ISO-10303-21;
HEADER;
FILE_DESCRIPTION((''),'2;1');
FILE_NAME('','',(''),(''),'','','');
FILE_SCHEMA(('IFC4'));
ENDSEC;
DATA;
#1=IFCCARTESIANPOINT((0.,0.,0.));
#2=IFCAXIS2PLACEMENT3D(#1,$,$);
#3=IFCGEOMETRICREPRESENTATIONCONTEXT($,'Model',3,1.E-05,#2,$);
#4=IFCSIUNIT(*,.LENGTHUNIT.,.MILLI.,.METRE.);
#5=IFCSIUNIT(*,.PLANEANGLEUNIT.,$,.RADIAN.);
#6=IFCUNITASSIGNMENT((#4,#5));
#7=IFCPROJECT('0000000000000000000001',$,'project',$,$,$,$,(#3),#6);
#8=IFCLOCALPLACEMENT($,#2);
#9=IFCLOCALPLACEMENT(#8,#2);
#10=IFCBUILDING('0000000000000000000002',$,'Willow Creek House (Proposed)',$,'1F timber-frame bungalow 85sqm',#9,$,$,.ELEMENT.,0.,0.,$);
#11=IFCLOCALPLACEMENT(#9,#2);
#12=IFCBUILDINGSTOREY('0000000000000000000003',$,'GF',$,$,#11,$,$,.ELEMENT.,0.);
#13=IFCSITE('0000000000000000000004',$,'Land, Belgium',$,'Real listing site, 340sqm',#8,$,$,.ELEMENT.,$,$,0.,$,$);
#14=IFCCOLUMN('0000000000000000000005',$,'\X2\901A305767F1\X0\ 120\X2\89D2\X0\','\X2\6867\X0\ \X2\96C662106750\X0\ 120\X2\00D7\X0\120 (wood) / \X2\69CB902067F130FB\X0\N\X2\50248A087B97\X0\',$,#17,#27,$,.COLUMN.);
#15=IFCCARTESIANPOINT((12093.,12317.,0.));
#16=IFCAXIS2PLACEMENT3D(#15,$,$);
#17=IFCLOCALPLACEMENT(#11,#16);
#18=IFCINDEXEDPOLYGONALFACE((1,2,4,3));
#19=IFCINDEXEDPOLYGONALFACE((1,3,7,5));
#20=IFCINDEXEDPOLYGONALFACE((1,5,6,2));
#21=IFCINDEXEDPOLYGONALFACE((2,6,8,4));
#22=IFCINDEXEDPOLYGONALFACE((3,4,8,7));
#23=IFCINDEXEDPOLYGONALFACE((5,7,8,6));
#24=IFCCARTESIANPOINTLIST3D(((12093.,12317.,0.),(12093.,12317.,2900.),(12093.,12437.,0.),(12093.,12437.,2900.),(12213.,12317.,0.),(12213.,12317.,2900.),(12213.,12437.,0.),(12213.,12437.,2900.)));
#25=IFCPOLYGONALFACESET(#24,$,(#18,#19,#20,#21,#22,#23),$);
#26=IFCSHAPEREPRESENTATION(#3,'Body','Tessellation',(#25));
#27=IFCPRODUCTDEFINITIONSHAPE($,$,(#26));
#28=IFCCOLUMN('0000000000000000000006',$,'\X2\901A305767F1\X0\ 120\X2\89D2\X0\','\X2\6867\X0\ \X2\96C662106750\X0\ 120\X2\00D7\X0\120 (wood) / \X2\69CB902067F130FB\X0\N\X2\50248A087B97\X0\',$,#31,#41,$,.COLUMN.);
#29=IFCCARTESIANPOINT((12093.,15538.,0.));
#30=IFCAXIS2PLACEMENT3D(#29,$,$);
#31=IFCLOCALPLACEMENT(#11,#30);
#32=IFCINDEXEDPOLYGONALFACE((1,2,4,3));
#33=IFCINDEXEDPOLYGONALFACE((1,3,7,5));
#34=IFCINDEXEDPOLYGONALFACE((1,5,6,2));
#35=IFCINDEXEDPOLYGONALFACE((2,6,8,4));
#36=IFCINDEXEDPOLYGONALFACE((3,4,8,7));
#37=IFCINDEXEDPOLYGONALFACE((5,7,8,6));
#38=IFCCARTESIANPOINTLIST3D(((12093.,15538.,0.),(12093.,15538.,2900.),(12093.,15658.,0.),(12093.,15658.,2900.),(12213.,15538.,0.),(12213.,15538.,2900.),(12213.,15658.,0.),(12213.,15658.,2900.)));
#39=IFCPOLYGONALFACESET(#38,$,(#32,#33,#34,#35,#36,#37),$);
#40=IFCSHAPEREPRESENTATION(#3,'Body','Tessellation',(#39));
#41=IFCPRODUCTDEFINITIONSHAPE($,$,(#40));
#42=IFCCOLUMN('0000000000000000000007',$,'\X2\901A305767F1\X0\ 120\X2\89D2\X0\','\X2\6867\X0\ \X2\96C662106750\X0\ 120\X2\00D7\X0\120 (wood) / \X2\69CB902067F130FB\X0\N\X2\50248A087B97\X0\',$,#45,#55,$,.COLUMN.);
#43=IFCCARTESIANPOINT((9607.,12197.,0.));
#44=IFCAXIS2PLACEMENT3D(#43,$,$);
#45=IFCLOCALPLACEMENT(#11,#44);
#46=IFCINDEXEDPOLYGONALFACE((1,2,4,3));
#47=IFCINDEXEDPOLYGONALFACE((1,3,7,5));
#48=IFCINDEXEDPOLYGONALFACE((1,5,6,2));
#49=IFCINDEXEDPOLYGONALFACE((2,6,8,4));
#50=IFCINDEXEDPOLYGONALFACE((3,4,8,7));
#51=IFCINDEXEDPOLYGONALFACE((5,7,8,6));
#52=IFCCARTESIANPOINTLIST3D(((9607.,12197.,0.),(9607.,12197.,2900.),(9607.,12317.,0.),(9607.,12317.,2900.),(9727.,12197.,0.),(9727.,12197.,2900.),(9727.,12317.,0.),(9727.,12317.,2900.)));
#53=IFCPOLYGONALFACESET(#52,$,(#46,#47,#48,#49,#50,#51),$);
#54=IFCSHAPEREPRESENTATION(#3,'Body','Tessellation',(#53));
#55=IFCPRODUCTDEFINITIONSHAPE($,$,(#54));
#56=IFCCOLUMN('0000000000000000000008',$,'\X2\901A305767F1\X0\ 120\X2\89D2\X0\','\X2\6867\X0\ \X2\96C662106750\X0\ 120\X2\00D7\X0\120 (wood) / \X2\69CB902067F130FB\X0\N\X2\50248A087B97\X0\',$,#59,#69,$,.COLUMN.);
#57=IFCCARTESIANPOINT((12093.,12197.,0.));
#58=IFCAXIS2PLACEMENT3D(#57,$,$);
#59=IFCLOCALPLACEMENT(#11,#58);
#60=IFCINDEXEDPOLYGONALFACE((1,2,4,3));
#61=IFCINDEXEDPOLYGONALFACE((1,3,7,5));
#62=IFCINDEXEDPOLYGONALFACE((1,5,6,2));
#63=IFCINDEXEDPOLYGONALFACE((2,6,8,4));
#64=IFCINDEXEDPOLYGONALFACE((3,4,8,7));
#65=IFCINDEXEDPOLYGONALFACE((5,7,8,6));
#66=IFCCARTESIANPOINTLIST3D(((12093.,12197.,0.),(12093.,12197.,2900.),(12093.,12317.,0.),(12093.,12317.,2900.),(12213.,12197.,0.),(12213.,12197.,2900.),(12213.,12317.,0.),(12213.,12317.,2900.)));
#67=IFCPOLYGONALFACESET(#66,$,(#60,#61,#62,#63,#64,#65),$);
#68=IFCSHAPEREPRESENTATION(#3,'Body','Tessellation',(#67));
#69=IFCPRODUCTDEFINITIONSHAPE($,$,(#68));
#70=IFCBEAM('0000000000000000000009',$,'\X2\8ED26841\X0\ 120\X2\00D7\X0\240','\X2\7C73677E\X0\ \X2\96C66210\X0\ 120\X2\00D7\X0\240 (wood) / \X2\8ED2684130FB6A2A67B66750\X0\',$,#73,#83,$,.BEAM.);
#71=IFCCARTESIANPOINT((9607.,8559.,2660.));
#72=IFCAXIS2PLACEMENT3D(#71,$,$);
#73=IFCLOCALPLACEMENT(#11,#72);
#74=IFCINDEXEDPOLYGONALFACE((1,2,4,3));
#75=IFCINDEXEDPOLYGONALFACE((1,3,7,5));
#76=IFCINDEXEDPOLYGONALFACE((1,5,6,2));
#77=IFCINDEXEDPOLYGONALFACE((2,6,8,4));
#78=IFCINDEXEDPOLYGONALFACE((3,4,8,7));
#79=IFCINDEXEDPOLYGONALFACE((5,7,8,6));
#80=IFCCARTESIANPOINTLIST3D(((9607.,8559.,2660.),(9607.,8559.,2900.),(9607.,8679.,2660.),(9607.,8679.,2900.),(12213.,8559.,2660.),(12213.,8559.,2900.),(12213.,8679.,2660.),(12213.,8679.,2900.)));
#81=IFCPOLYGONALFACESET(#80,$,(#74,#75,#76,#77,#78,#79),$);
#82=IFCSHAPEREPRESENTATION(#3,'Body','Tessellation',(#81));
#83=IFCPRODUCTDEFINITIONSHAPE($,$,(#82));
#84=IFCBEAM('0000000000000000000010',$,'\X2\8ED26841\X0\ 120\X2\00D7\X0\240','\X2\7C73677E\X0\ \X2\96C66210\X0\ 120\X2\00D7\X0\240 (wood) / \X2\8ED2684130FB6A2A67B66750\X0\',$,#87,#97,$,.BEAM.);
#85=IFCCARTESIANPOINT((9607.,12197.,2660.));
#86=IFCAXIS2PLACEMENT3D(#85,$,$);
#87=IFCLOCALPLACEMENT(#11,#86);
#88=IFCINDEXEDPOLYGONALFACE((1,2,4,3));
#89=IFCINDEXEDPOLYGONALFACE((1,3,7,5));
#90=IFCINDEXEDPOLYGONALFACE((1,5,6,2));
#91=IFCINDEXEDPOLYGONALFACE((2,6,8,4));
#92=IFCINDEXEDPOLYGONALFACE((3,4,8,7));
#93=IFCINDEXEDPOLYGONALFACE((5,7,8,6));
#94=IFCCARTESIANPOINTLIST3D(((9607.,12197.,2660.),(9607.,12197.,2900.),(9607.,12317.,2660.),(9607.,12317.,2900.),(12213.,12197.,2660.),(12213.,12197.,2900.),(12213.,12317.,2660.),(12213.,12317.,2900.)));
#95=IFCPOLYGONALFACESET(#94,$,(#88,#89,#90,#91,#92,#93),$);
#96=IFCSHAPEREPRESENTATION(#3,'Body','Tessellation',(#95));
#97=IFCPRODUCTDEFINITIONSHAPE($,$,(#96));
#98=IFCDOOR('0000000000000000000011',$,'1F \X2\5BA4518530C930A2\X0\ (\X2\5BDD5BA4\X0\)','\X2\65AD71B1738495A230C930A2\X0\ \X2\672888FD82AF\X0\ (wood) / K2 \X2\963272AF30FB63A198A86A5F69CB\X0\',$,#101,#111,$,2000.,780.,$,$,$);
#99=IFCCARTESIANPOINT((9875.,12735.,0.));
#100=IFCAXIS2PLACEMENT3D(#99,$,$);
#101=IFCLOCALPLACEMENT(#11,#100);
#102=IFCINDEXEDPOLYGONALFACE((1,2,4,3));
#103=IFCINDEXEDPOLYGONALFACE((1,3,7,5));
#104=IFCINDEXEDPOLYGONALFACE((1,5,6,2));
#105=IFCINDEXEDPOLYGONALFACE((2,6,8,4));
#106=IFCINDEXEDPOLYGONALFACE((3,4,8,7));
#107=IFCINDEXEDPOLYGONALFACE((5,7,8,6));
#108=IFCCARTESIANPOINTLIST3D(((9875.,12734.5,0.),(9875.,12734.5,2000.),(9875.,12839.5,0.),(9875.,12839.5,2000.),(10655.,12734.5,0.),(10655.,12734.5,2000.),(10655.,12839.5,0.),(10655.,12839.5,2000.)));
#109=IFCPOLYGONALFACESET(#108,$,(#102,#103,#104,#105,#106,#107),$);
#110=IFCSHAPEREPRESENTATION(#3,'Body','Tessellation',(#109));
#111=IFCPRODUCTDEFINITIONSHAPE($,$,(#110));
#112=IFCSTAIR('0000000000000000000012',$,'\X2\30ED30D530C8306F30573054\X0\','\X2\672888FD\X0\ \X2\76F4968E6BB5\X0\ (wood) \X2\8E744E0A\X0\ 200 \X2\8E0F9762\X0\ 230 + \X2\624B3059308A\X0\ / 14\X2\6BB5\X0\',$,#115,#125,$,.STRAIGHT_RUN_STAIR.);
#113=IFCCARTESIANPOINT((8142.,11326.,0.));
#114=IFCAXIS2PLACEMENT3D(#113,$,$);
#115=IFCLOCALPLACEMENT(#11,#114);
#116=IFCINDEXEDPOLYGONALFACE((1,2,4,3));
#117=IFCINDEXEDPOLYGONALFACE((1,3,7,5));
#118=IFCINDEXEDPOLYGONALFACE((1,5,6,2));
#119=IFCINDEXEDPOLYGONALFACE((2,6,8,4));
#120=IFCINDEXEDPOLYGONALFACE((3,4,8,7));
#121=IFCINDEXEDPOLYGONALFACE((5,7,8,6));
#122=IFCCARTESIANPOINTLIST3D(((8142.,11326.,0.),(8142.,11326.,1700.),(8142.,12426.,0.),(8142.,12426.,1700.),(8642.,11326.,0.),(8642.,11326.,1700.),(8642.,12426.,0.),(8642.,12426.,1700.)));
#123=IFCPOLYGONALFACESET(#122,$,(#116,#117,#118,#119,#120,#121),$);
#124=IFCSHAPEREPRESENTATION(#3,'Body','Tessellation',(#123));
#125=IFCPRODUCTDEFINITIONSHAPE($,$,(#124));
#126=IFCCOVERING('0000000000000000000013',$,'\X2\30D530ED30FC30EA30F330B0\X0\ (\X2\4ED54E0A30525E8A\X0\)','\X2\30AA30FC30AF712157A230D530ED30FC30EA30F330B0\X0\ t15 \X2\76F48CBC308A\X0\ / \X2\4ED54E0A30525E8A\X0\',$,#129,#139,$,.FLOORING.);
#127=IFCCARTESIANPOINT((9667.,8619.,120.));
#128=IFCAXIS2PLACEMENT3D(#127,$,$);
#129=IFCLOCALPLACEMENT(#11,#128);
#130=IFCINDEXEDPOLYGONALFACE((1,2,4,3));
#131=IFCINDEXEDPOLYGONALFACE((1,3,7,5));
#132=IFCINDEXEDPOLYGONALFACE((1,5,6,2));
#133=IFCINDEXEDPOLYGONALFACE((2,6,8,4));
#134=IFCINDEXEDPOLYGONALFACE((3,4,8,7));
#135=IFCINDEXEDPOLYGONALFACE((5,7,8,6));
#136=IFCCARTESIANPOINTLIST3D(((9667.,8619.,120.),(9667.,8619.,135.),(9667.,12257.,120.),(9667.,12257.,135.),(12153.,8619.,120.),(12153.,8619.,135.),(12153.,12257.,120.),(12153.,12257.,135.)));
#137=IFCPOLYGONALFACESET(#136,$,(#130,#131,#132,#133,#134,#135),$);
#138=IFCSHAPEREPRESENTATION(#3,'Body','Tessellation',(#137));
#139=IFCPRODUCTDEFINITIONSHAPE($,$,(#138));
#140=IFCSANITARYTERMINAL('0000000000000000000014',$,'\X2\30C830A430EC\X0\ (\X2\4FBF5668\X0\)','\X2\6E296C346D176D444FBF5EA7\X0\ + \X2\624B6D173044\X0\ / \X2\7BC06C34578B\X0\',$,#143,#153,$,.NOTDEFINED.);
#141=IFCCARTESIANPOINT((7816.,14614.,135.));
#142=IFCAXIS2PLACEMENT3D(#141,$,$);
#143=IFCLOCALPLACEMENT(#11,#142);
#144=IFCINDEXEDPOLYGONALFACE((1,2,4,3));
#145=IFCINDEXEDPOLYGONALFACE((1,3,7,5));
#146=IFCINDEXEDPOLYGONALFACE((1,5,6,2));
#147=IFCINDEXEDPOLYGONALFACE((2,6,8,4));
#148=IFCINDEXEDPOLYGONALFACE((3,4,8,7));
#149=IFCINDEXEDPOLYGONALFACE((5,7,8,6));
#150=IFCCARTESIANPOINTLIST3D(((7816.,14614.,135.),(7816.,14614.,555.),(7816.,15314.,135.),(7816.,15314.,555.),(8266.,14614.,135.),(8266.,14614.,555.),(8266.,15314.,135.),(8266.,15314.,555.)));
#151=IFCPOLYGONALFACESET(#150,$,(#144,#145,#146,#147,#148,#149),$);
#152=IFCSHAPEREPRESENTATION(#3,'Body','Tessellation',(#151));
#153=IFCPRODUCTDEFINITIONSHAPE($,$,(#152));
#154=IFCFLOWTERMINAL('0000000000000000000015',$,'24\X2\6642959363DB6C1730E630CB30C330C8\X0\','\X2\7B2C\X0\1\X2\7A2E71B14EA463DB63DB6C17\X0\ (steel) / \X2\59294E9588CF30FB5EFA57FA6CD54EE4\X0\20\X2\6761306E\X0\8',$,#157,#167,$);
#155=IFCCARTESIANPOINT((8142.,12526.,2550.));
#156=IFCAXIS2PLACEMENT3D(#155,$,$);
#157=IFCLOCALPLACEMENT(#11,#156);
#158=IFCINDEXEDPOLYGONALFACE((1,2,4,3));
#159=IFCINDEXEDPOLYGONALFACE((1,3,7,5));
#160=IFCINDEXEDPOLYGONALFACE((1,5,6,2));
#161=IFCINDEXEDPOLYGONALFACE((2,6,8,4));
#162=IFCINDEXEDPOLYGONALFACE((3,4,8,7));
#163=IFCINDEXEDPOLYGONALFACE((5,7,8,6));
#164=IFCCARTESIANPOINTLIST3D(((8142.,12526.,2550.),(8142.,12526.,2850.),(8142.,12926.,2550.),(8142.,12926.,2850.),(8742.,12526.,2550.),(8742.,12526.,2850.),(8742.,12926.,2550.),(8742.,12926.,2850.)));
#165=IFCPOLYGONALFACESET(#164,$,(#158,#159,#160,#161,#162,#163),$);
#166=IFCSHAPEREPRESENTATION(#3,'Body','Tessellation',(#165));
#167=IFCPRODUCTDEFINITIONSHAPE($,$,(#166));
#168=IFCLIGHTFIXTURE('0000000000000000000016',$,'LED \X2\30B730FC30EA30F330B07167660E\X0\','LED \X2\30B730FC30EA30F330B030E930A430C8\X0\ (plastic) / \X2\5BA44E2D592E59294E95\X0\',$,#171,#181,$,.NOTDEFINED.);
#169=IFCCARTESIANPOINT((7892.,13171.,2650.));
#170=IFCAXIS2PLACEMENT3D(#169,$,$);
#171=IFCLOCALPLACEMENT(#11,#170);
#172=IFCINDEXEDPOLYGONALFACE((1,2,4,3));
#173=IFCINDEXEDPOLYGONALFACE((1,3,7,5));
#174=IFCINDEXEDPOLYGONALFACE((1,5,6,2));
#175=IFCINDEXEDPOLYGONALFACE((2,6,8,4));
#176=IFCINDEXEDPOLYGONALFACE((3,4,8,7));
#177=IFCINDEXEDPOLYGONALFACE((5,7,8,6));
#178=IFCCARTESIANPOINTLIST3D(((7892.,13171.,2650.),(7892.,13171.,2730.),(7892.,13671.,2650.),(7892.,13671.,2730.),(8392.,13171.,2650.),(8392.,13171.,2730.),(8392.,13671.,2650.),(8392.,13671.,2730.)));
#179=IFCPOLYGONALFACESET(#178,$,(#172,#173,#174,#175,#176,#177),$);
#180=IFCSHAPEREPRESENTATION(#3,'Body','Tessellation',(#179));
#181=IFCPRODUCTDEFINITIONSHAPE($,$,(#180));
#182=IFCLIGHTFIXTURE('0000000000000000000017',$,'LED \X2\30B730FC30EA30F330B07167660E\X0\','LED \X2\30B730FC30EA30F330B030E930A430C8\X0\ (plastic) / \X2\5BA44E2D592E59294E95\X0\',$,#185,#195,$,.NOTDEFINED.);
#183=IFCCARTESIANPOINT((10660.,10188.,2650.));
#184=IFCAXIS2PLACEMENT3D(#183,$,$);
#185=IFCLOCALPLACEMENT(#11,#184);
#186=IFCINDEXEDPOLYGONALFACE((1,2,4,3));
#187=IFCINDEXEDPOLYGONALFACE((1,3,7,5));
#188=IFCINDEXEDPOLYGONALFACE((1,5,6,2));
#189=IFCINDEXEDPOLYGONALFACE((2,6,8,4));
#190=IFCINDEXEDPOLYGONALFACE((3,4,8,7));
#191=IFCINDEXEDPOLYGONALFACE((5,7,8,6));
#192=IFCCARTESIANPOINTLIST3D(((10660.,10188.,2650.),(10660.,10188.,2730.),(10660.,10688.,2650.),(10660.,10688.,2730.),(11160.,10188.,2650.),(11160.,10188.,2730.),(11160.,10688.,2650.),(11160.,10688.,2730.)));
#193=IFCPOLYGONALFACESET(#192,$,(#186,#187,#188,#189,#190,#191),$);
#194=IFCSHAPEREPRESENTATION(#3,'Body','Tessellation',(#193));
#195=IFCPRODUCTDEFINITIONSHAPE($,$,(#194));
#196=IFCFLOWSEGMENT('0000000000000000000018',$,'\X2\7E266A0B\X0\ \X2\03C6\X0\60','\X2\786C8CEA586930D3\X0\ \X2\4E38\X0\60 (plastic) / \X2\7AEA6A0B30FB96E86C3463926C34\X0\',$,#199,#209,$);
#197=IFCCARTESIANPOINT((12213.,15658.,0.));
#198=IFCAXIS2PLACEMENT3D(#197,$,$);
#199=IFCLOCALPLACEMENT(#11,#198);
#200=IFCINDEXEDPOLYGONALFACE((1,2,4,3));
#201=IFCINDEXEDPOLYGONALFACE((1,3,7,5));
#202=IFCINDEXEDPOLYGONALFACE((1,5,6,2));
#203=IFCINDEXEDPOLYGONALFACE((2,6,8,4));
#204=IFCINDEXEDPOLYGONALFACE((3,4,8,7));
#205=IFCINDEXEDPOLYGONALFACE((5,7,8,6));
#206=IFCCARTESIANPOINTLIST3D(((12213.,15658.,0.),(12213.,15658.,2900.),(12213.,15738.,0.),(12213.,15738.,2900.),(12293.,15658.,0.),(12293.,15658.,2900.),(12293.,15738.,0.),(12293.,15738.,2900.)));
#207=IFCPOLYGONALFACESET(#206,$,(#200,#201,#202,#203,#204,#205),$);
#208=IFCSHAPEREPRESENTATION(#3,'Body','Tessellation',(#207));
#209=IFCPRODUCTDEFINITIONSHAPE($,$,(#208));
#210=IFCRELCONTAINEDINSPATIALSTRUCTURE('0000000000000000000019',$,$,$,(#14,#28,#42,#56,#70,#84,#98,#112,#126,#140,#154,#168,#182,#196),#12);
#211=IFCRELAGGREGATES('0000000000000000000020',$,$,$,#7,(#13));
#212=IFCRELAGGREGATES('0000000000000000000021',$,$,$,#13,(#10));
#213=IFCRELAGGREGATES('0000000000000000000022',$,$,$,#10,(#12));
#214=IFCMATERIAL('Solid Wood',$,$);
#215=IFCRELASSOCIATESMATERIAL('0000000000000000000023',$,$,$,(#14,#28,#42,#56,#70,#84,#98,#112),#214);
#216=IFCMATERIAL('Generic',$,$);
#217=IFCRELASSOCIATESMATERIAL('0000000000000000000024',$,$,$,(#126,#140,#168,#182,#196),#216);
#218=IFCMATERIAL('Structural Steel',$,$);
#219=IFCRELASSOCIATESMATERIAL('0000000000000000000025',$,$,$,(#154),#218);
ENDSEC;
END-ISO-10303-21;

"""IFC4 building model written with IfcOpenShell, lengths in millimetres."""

from ifc_helpers import new_model, si_unit, frame, frame_2d, origin, place, context, project, spatial, rectangle, extrude, material, element, save


model = new_model("IFC4")

# Units and contexts
model_context = context("Model", 3, precision=1e-05, world=origin())
ifc_project = project(units=[si_unit("LENGTHUNIT", "METRE", prefix="MILLI"), si_unit("PLANEANGLEUNIT", "RADIAN")], contexts=[model_context])

# Site, building, storey
site_placement = place(None, origin())
site = spatial("IfcSite", under=ifc_project, at=site_placement, Name="Land, Belgium", ObjectType="Real listing site, 340sqm", CompositionType="ELEMENT", RefElevation=0.0)
building_placement = place(site_placement, origin())
building = spatial("IfcBuilding", under=site, at=building_placement, Name="Willow Creek House (Proposed)", ObjectType="1F timber-frame bungalow 85sqm", CompositionType="ELEMENT", ElevationOfRefHeight=0.0, ElevationOfTerrain=0.0)
storey_placement = place(building_placement, origin())
storey = spatial("IfcBuildingStorey", under=building, at=storey_placement, Name="GF", CompositionType="ELEMENT", Elevation=0.0)

# Columns
ifc_material_1 = material(Name="Solid Wood")
column_1_placement = place(storey_placement, frame((12093.0, 12317.0, 0.0)))
element("IfcColumn", 1, at=column_1_placement, inside=storey, material=ifc_material_1, Name="通し柱 120角", Description="桧 集成材 120×120 (wood) / 構造柱・N値計算", PredefinedType="COLUMN", context=model_context, shape_type="SweptSolid", body=[
    extrude(rectangle(XDim=120.0, YDim=120.0, at=frame_2d((60.0, 60.0))), frame((12093.0, 12317.0, 0.0)), (0.0, 0.0, 1.0), 2900.0),
])
column_2_placement = place(storey_placement, frame((12093.0, 15538.0, 0.0)))
element("IfcColumn", 2, at=column_2_placement, inside=storey, material=ifc_material_1, Name="通し柱 120角", Description="桧 集成材 120×120 (wood) / 構造柱・N値計算", PredefinedType="COLUMN", context=model_context, shape_type="SweptSolid", body=[
    extrude(rectangle(XDim=120.0, YDim=120.0, at=frame_2d((60.0, 60.0))), frame((12093.0, 15538.0, 0.0)), (0.0, 0.0, 1.0), 2900.0),
])
column_3_placement = place(storey_placement, frame((9607.0, 12197.0, 0.0)))
element("IfcColumn", 3, at=column_3_placement, inside=storey, material=ifc_material_1, Name="通し柱 120角", Description="桧 集成材 120×120 (wood) / 構造柱・N値計算", PredefinedType="COLUMN", context=model_context, shape_type="SweptSolid", body=[
    extrude(rectangle(XDim=120.0, YDim=120.0, at=frame_2d((60.0, 60.0))), frame((9607.0, 12197.0, 0.0)), (0.0, 0.0, 1.0), 2900.0),
])
column_4_placement = place(storey_placement, frame((12093.0, 12197.0, 0.0)))
element("IfcColumn", 4, at=column_4_placement, inside=storey, material=ifc_material_1, Name="通し柱 120角", Description="桧 集成材 120×120 (wood) / 構造柱・N値計算", PredefinedType="COLUMN", context=model_context, shape_type="SweptSolid", body=[
    extrude(rectangle(XDim=120.0, YDim=120.0, at=frame_2d((60.0, 60.0))), frame((12093.0, 12197.0, 0.0)), (0.0, 0.0, 1.0), 2900.0),
])

# Beams
beam_1_placement = place(storey_placement, frame((9607.0, 8559.0, 2660.0)))
element("IfcBeam", 5, at=beam_1_placement, inside=storey, material=ifc_material_1, Name="軒桁 120×240", Description="米松 集成 120×240 (wood) / 軒桁・横架材", PredefinedType="BEAM", context=model_context, shape_type="SweptSolid", body=[
    extrude(rectangle(XDim=2606.0, YDim=120.0, at=frame_2d((1303.0, 60.0))), frame((9607.0, 8559.0, 2660.0)), (0.0, 0.0, 1.0), 240.0),
])
beam_2_placement = place(storey_placement, frame((9607.0, 12197.0, 2660.0)))
element("IfcBeam", 6, at=beam_2_placement, inside=storey, material=ifc_material_1, Name="軒桁 120×240", Description="米松 集成 120×240 (wood) / 軒桁・横架材", PredefinedType="BEAM", context=model_context, shape_type="SweptSolid", body=[
    extrude(rectangle(XDim=2606.0, YDim=120.0, at=frame_2d((1303.0, 60.0))), frame((9607.0, 12197.0, 2660.0)), (0.0, 0.0, 1.0), 240.0),
])

# Door
door_placement = place(storey_placement, frame((9875.0, 12735.0, 0.0)))
element("IfcDoor", 7, at=door_placement, inside=storey, material=ifc_material_1, Name="1F 室内ドア (寝室)", Description="断熱玄関ドア 木製芯 (wood) / K2 防犯・採風機構", OverallHeight=2000.0, OverallWidth=780.0, context=model_context, shape_type="SweptSolid", body=[
    extrude(rectangle(XDim=780.0, YDim=105.0, at=frame_2d((390.0, 52.0))), frame((9875.0, 12735.0, 0.0)), (0.0, 0.0, 1.0), 2000.0),
])

# Stair
stair_placement = place(storey_placement, frame((8142.0, 11326.0, 0.0)))
element("IfcStair", 8, at=stair_placement, inside=storey, material=ifc_material_1, Name="ロフトはしご", Description="木製 直階段 (wood) 蹴上 200 踏面 230 + 手すり / 14段", PredefinedType="STRAIGHT_RUN_STAIR", context=model_context, shape_type="SweptSolid", body=[
    extrude(rectangle(XDim=500.0, YDim=1100.0, at=frame_2d((250.0, 550.0))), frame((8142.0, 11326.0, 0.0)), (0.0, 0.0, 1.0), 1700.0),
])

# Covering
ifc_material_2 = material(Name="Generic")
covering_placement = place(storey_placement, frame((9667.0, 8619.0, 120.0)))
element("IfcCovering", 9, at=covering_placement, inside=storey, material=ifc_material_2, Name="フローリング (仕上げ床)", Description="オーク無垢フローリング t15 直貼り / 仕上げ床", PredefinedType="FLOORING", context=model_context, shape_type="SweptSolid", body=[
    extrude(rectangle(XDim=2486.0, YDim=3638.0, at=frame_2d((1243.0, 1819.0))), frame((9667.0, 8619.0, 120.0)), (0.0, 0.0, 1.0), 15.0),
])

# Sanitary terminal
sanitary_terminal_placement = place(storey_placement, frame((7816.0, 14614.0, 135.0)))
element("IfcSanitaryTerminal", 10, at=sanitary_terminal_placement, inside=storey, material=ifc_material_2, Name="トイレ (便器)", Description="温水洗浄便座 + 手洗い / 節水型", PredefinedType="NOTDEFINED", context=model_context, shape_type="SweptSolid", body=[
    extrude(rectangle(XDim=450.0, YDim=700.0, at=frame_2d((225.0, 350.0))), frame((7816.0, 14614.0, 135.0)), (0.0, 0.0, 1.0), 420.0),
])

# Flow terminal
ifc_material_3 = material(Name="Structural Steel")
flow_terminal_placement = place(storey_placement, frame((8142.0, 12526.0, 2550.0)))
element("IfcFlowTerminal", 11, at=flow_terminal_placement, inside=storey, material=ifc_material_3, Name="24時間換気ユニット", Description="第1種熱交換換気 (steel) / 天井裏・建基法令20条の8", context=model_context, shape_type="SweptSolid", body=[
    extrude(rectangle(XDim=600.0, YDim=400.0, at=frame_2d((300.0, 200.0))), frame((8142.0, 12526.0, 2550.0)), (0.0, 0.0, 1.0), 300.0),
])

# Light fixtures
light_fixture_1_placement = place(storey_placement, frame((7892.0, 13171.0, 2650.0)))
element("IfcLightFixture", 12, at=light_fixture_1_placement, inside=storey, material=ifc_material_2, Name="LED シーリング照明", Description="LED シーリングライト (plastic) / 室中央天井", PredefinedType="NOTDEFINED", context=model_context, shape_type="SweptSolid", body=[
    extrude(rectangle(XDim=500.0, YDim=500.0, at=frame_2d((250.0, 250.0))), frame((7892.0, 13171.0, 2650.0)), (0.0, 0.0, 1.0), 80.0),
])
light_fixture_2_placement = place(storey_placement, frame((10660.0, 10188.0, 2650.0)))
element("IfcLightFixture", 13, at=light_fixture_2_placement, inside=storey, material=ifc_material_2, Name="LED シーリング照明", Description="LED シーリングライト (plastic) / 室中央天井", PredefinedType="NOTDEFINED", context=model_context, shape_type="SweptSolid", body=[
    extrude(rectangle(XDim=500.0, YDim=500.0, at=frame_2d((250.0, 250.0))), frame((10660.0, 10188.0, 2650.0)), (0.0, 0.0, 1.0), 80.0),
])

# Flow segment
flow_segment_placement = place(storey_placement, frame((12213.0, 15658.0, 0.0)))
element("IfcFlowSegment", 14, at=flow_segment_placement, inside=storey, material=ifc_material_2, Name="縦樋 φ60", Description="硬質塩ビ 丸60 (plastic) / 竪樋・雨水排水", context=model_context, shape_type="SweptSolid", body=[
    extrude(rectangle(XDim=80.0, YDim=80.0, at=frame_2d((40.0, 40.0))), frame((12213.0, 15658.0, 0.0)), (0.0, 0.0, 1.0), 2900.0),
])

save(model, "model.ifc")
